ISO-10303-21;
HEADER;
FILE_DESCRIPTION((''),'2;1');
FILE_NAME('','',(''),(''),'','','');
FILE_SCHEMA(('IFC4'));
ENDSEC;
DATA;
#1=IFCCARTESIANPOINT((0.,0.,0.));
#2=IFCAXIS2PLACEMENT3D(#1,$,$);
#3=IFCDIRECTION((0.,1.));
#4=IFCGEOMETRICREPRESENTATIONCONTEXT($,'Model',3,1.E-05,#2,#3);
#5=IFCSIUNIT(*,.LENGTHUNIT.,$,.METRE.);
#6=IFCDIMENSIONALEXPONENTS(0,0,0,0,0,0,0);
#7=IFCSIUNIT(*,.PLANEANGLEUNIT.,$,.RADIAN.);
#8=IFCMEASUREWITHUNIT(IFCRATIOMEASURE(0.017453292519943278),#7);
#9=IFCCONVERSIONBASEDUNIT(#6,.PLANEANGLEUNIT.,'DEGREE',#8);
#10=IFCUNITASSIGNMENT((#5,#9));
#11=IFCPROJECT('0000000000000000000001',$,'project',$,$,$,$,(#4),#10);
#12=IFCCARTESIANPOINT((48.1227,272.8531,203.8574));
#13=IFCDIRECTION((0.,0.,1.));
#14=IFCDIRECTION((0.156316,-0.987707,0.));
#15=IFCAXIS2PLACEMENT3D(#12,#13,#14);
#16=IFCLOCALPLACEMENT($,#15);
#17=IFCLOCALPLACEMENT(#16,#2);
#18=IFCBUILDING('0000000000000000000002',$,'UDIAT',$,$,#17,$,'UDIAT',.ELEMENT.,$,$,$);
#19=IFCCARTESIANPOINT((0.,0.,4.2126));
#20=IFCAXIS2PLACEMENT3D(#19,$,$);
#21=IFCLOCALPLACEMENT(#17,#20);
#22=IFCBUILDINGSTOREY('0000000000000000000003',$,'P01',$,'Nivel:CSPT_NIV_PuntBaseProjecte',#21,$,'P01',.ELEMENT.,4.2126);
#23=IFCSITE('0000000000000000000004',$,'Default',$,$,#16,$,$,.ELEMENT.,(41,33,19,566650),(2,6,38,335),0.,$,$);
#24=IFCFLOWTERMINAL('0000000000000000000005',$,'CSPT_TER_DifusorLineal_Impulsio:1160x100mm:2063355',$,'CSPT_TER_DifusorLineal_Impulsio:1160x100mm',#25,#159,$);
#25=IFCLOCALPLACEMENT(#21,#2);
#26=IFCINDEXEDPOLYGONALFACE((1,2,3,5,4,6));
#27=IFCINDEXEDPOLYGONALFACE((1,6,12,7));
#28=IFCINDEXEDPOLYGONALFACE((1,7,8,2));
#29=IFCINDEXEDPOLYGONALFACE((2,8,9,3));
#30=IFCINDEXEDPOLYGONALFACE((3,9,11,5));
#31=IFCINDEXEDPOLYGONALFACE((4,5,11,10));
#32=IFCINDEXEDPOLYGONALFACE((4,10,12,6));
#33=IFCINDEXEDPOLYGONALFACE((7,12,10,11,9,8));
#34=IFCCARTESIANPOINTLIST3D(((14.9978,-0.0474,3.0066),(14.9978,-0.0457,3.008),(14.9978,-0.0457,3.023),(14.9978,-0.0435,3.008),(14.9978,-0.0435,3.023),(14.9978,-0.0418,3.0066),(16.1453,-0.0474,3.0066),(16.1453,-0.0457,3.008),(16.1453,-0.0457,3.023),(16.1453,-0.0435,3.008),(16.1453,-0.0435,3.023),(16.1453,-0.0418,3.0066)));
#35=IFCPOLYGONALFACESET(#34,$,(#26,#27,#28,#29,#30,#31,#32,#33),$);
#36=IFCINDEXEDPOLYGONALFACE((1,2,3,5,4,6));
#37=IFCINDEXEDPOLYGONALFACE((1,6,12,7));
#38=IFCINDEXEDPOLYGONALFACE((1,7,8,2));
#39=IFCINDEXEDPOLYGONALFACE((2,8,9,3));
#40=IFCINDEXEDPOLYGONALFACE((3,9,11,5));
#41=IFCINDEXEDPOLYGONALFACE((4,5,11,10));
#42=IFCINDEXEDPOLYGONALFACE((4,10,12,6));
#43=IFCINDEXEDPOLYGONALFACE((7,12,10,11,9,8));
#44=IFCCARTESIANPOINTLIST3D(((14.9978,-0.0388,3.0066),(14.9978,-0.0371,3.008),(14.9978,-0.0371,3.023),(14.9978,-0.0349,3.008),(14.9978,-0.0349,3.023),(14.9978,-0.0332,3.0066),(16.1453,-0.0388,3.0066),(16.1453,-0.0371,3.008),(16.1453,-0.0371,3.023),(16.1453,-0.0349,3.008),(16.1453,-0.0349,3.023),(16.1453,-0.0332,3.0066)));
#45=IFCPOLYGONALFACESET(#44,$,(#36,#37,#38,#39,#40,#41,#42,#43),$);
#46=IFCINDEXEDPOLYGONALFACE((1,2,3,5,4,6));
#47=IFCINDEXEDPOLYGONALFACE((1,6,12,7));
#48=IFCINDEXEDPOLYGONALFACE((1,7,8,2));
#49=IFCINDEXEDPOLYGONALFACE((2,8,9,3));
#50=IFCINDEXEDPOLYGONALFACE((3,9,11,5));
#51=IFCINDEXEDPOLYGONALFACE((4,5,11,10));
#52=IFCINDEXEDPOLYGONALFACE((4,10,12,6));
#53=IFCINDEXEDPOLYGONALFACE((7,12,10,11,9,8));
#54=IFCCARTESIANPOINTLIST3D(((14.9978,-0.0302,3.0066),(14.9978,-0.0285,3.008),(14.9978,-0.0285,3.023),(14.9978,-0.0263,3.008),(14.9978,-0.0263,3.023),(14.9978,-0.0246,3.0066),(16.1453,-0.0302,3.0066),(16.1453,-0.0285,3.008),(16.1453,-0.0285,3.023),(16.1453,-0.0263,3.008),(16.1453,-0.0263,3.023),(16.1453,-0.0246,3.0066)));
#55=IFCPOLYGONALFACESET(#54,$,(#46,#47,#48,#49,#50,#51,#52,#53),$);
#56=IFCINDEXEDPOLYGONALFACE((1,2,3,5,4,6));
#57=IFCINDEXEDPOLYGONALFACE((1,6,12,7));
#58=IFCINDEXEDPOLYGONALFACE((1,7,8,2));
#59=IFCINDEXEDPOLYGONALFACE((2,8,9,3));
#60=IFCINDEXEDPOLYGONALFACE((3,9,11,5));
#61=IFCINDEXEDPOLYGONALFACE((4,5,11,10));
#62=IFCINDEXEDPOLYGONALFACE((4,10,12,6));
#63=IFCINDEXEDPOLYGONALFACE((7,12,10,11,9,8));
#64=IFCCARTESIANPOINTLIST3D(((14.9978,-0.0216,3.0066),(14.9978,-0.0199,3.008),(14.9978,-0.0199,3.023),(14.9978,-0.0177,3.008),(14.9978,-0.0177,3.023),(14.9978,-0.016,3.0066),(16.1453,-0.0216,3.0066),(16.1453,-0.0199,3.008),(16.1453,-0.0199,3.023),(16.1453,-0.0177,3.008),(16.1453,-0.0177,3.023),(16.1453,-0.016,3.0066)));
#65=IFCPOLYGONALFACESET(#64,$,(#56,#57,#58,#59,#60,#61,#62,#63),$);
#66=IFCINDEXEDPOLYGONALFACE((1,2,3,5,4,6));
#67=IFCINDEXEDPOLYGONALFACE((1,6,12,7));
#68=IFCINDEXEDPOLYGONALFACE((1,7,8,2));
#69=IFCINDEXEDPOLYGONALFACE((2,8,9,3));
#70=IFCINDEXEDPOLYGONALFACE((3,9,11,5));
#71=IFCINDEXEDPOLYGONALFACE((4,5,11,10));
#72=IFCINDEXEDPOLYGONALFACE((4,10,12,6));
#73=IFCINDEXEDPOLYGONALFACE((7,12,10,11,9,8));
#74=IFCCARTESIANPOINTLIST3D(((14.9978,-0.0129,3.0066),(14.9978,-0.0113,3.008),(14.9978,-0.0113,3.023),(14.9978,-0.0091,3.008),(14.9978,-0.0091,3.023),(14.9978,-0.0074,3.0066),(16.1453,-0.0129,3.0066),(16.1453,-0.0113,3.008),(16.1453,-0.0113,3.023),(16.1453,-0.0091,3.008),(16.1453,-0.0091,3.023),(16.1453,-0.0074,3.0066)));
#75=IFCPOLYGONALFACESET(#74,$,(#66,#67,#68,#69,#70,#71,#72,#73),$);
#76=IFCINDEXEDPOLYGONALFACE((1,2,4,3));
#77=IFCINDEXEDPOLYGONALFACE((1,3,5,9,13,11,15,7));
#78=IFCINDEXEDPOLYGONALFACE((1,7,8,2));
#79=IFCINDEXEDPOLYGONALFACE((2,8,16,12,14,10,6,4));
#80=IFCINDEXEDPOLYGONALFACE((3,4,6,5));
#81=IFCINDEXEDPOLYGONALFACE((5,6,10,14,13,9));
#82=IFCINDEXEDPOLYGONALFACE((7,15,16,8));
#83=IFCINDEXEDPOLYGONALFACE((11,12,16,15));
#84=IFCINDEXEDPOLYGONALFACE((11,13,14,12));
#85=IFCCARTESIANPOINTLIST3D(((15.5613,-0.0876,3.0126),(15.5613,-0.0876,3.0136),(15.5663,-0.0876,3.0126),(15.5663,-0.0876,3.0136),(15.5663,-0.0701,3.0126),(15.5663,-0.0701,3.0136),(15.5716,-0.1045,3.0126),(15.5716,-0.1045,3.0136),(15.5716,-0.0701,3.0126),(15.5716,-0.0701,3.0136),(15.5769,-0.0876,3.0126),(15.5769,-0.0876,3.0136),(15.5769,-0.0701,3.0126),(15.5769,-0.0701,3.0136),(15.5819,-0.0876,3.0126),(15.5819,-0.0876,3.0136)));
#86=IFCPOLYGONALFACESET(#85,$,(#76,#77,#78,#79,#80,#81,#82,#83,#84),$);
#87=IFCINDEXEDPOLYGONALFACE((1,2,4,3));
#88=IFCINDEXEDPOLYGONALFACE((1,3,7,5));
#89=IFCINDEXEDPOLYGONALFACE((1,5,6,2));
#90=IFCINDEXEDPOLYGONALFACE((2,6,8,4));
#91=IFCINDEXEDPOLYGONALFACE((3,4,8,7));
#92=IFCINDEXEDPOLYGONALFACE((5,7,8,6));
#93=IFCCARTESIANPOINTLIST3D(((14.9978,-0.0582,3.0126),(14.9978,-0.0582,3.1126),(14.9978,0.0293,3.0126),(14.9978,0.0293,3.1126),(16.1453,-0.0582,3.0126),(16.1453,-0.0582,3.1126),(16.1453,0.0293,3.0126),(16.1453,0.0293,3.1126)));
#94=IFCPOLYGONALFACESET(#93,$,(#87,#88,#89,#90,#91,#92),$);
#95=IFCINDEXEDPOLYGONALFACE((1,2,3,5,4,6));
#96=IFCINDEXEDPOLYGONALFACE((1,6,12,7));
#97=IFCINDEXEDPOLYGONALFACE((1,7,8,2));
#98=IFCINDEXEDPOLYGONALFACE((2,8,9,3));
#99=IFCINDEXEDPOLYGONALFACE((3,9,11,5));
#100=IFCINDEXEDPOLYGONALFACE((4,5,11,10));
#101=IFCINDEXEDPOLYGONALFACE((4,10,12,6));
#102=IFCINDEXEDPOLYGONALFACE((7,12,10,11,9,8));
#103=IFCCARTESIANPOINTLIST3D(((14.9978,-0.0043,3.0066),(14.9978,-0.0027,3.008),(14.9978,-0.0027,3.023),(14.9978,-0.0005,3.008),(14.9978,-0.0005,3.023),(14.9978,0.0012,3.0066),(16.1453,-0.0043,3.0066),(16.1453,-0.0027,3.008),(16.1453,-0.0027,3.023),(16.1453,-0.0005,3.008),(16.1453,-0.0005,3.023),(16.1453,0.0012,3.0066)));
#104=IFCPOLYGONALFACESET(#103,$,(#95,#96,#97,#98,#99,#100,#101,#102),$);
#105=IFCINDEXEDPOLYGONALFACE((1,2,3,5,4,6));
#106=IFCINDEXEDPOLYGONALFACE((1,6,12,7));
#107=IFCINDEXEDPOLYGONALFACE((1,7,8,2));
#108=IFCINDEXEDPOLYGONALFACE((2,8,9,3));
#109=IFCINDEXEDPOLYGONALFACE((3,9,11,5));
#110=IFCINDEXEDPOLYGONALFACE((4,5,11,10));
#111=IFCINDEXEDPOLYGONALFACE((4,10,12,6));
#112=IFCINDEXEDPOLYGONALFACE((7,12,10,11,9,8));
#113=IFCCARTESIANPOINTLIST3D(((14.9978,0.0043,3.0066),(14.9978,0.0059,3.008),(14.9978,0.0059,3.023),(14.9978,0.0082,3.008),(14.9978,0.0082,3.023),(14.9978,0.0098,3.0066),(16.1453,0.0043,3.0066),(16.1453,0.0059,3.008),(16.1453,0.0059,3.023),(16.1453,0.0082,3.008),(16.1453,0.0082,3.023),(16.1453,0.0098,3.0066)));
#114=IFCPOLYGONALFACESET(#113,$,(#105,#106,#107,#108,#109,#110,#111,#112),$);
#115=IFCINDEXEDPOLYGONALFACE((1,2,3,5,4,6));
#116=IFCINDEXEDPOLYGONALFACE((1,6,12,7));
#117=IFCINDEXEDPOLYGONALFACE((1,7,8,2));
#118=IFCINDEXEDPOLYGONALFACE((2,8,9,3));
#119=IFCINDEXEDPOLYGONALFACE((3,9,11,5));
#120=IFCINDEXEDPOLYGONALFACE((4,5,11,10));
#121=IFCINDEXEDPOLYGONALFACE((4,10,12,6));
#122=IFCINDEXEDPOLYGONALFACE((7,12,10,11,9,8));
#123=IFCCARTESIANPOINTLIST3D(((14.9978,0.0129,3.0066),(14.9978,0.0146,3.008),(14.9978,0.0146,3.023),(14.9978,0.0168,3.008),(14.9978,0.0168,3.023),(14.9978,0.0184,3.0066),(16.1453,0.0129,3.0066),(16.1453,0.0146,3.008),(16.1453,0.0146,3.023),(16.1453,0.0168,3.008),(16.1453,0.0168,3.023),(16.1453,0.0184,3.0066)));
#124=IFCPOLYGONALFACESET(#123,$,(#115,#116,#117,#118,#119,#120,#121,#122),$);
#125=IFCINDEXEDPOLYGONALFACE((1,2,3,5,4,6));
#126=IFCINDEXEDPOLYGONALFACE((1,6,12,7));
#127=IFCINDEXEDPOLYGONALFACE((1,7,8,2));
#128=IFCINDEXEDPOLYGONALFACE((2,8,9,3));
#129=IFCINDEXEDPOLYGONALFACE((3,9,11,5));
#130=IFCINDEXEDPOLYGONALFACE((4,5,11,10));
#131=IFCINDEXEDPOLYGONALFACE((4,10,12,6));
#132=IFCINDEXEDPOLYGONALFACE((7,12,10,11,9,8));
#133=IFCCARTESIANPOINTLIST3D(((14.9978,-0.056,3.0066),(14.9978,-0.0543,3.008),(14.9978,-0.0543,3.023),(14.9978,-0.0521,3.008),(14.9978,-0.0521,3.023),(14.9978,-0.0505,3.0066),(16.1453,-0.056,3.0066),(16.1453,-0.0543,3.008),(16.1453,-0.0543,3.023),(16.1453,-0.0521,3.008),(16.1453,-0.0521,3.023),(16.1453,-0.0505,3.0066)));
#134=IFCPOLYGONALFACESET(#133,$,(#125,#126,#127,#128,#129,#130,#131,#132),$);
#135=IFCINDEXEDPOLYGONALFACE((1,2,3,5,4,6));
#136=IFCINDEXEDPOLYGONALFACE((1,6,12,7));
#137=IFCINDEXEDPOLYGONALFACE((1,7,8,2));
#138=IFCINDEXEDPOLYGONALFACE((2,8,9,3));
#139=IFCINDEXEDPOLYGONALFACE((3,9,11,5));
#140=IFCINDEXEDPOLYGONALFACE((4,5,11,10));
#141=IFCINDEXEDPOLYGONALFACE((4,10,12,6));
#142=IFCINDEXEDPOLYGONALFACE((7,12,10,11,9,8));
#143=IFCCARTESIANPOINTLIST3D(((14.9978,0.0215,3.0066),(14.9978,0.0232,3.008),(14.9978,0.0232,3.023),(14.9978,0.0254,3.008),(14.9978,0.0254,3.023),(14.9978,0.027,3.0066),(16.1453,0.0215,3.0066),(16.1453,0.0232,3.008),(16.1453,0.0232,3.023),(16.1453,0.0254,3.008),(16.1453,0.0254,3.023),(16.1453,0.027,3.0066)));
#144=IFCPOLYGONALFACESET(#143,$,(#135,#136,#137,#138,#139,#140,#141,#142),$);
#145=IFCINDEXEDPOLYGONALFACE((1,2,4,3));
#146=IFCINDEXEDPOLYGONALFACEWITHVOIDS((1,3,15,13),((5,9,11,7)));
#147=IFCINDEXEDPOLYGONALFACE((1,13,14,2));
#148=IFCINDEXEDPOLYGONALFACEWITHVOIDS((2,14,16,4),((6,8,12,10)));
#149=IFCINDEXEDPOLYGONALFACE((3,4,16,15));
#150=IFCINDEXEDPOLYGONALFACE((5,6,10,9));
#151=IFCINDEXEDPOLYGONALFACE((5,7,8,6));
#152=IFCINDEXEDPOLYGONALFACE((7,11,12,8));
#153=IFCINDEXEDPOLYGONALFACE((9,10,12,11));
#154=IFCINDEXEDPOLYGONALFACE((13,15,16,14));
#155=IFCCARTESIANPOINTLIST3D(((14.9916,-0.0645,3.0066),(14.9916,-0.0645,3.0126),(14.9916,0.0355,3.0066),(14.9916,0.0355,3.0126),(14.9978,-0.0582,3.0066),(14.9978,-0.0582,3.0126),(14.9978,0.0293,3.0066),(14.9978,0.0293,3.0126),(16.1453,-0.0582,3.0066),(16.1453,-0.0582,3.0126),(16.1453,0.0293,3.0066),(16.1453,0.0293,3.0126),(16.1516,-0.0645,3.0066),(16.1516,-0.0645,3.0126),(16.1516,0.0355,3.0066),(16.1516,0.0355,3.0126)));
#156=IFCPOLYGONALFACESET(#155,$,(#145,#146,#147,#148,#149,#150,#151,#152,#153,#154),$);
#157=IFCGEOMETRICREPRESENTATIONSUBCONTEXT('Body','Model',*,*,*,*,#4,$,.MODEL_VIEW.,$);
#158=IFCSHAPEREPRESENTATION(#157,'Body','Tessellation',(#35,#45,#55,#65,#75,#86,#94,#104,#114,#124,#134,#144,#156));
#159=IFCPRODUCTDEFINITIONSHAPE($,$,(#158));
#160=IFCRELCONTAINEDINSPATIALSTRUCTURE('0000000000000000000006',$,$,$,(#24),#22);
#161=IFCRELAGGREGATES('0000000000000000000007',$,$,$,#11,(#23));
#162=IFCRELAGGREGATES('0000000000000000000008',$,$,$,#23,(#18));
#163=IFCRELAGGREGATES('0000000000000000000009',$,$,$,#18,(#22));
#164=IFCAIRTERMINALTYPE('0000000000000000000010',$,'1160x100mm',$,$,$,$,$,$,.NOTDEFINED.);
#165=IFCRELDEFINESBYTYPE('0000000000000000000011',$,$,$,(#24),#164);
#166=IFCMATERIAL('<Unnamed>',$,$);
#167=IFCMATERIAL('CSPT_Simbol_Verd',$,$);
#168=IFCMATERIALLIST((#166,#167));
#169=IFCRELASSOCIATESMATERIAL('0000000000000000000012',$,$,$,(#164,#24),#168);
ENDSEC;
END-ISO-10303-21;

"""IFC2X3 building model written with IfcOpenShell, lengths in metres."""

from ifc_helpers import new_model, entity, si_unit, converted_unit, direction, frame, origin, origin_2d_with_axis, place, context, subcontext, project, spatial, polyline, rectangle, outline, extrude, source, transform, mapped, material, material_list, type_object, type_shapes, element, save


model = new_model("IFC2X3")

# Units and contexts
model_context = context("Model", 3, precision=1e-05, world=origin(), true_north=direction((0.0, 1.0)))
body_context = subcontext(model_context, "Body", "Model", "MODEL_VIEW")
ifc_project = project(units=[si_unit("LENGTHUNIT", "METRE"), converted_unit("PLANEANGLEUNIT", "DEGREE", entity("IfcRatioMeasure", 0.017453292519943278), si_unit("PLANEANGLEUNIT", "RADIAN"), dimensions=[0, 0, 0, 0, 0, 0, 0])], contexts=[model_context])

# Site, building, storey
site_placement = place(None, frame((48.1227, 272.8531, 203.8574), z_axis=(0.0, 0.0, 1.0), x_axis=(0.156316, -0.987707, 0.0)))
site = spatial("IfcSite", under=ifc_project, at=site_placement, Name="Default", CompositionType="ELEMENT", RefLatitude=(41, 33, 19, 566650), RefLongitude=(2, 6, 38, 335), RefElevation=0.0)
building_placement = place(site_placement, origin())
building = spatial("IfcBuilding", under=site, at=building_placement, Name="UDIAT", LongName="UDIAT", CompositionType="ELEMENT")
storey_placement = place(building_placement, frame((0.0, 0.0, 4.2126)))
storey = spatial("IfcBuildingStorey", under=building, at=storey_placement, Name="P01", ObjectType="Nivel:CSPT_NIV_PuntBaseProjecte", LongName="P01", CompositionType="ELEMENT", Elevation=4.2126)

# Shared definitions
ifc_material_1 = material(Name="<Unnamed>")

# Flow terminal
ifc_material_2 = material(Name="CSPT_Simbol_Verd")
ifc_material_list = material_list([ifc_material_1, ifc_material_2])
air_terminal_type = type_object("IfcAirTerminalType", Name="1160x100mm", PredefinedType="NOTDEFINED", material=ifc_material_list)
shared_shape_1 = source(origin(), body_context, "Body", "SweptSolid", [
    extrude(outline(polyline([(0.0037, 0.0028), (0.0059, 0.0028), (0.0016, 0.0063), (0.002, 0.0042), (-0.0074, -0.0074), (-0.0057, -0.0088), (0.0037, 0.0028)])), frame((-0.5737, 0.0301, -0.0001), z_axis=(1.0, 0.0, 0.0), x_axis=(0.0, -0.776119, -0.630587)), (0.0, 0.0, 1.0), 1.1475),
    extrude(outline(polyline([(0.0037, 0.0028), (0.0059, 0.0028), (0.0016, 0.0063), (0.002, 0.0042), (-0.0074, -0.0074), (-0.0057, -0.0088), (0.0037, 0.0028)])), frame((-0.5737, 0.0215, -0.0001), z_axis=(1.0, 0.0, 0.0), x_axis=(0.0, -0.776119, -0.630587)), (0.0, 0.0, 1.0), 1.1475),
    extrude(outline(polyline([(0.0037, 0.0028), (0.0059, 0.0028), (0.0016, 0.0063), (0.002, 0.0042), (-0.0074, -0.0074), (-0.0057, -0.0088), (0.0037, 0.0028)])), frame((-0.5737, 0.0129, -0.0001), z_axis=(1.0, 0.0, 0.0), x_axis=(0.0, -0.776119, -0.630587)), (0.0, 0.0, 1.0), 1.1475),
    extrude(outline(polyline([(0.0037, 0.0028), (0.0059, 0.0028), (0.0016, 0.0063), (0.002, 0.0042), (-0.0074, -0.0074), (-0.0057, -0.0088), (0.0037, 0.0028)])), frame((-0.5737, 0.0043, -0.0001), z_axis=(1.0, 0.0, 0.0), x_axis=(0.0, -0.776119, -0.630587)), (0.0, 0.0, 1.0), 1.1475),
    extrude(outline(polyline([(0.0037, 0.0028), (0.0059, 0.0028), (0.0016, 0.0063), (0.002, 0.0042), (-0.0074, -0.0074), (-0.0057, -0.0088), (0.0037, 0.0028)])), frame((-0.5737, -0.0043, -0.0001), z_axis=(1.0, 0.0, 0.0), x_axis=(0.0, -0.776119, -0.630587)), (0.0, 0.0, 1.0), 1.1475),
    extrude(outline(polyline([(0.0, -0.013), (0.0053, -0.013), (0.0053, 0.0045), (0.0103, 0.0045), (0.0, 0.0213), (-0.0103, 0.0045), (-0.0053, 0.0045), (-0.0053, -0.013), (0.0, -0.013)])), frame((0.0, 0.0687, 0.0)), (0.0, 0.0, 1.0), 0.001),
    extrude(rectangle(XDim=1.1475, YDim=0.0875, at=origin_2d_with_axis()), frame((0.0, 0.0, 0.0), z_axis=(0.0, 0.0, 1.0), x_axis=(-1.0, 0.0, 0.0)), (0.0, 0.0, 1.0), 0.1),
    extrude(outline(polyline([(0.0037, 0.0028), (0.0059, 0.0028), (0.0016, 0.0063), (0.002, 0.0042), (-0.0074, -0.0074), (-0.0057, -0.0088), (0.0037, 0.0028)])), frame((-0.5737, -0.0129, -0.0001), z_axis=(1.0, 0.0, 0.0), x_axis=(0.0, -0.776119, -0.630587)), (0.0, 0.0, 1.0), 1.1475),
    extrude(outline(polyline([(0.0037, 0.0028), (0.0059, 0.0028), (0.0016, 0.0063), (0.002, 0.0042), (-0.0074, -0.0074), (-0.0057, -0.0088), (0.0037, 0.0028)])), frame((-0.5737, -0.0215, -0.0001), z_axis=(1.0, 0.0, 0.0), x_axis=(0.0, -0.776119, -0.630587)), (0.0, 0.0, 1.0), 1.1475),
    extrude(outline(polyline([(0.0037, 0.0028), (0.0059, 0.0028), (0.0016, 0.0063), (0.002, 0.0042), (-0.0074, -0.0074), (-0.0057, -0.0088), (0.0037, 0.0028)])), frame((-0.5737, -0.0301, -0.0001), z_axis=(1.0, 0.0, 0.0), x_axis=(0.0, -0.776119, -0.630587)), (0.0, 0.0, 1.0), 1.1475),
    extrude(outline(polyline([(0.0037, 0.0028), (0.0059, 0.0028), (0.0016, 0.0063), (0.002, 0.0042), (-0.0074, -0.0074), (-0.0057, -0.0088), (0.0037, 0.0028)])), frame((-0.5737, 0.0388, -0.0001), z_axis=(1.0, 0.0, 0.0), x_axis=(0.0, -0.776119, -0.630587)), (0.0, 0.0, 1.0), 1.1475),
    extrude(outline(polyline([(0.0037, 0.0028), (0.0059, 0.0028), (0.0016, 0.0063), (0.002, 0.0042), (-0.0074, -0.0074), (-0.0057, -0.0088), (0.0037, 0.0028)])), frame((-0.5737, -0.0387, -0.0001), z_axis=(1.0, 0.0, 0.0), x_axis=(0.0, -0.776119, -0.630587)), (0.0, 0.0, 1.0), 1.1475),
    extrude(outline(polyline([(-0.58, -0.05), (0.58, -0.05), (0.58, 0.05), (-0.58, 0.05), (-0.58, -0.05)]), holes=[polyline([(-0.5738, -0.0438), (-0.5738, 0.0437), (0.5737, 0.0437), (0.5737, -0.0438), (-0.5738, -0.0438)])]), frame((0.0, 0.0, -0.006), z_axis=(0.0, 0.0, 1.0), x_axis=(-1.0, 0.0, 0.0)), (0.0, 0.0, 1.0), 0.006),
])
type_shapes(air_terminal_type, [shared_shape_1])
for number, where, z_axis, x_axis, name in (
    (1, (15.5716, -0.0145, 3.0126), (0.0, 0.0, 1.0), (-1.0, 0.0, 0.0), "CSPT_TER_DifusorLineal_Impulsio:1160x100mm:2063355"),
):
    element("IfcFlowTerminal", number, at=place(storey_placement, frame(where, z_axis=z_axis, x_axis=x_axis)), inside=storey, type_object=air_terminal_type, material=ifc_material_list, Name=name, ObjectType="CSPT_TER_DifusorLineal_Impulsio:1160x100mm", context=body_context, shape_type="MappedRepresentation", body=[
        mapped(shared_shape_1, transform((0.0, 0.0, 0.0), scale=1.0)),
    ])

save(model, "model.ifc")
